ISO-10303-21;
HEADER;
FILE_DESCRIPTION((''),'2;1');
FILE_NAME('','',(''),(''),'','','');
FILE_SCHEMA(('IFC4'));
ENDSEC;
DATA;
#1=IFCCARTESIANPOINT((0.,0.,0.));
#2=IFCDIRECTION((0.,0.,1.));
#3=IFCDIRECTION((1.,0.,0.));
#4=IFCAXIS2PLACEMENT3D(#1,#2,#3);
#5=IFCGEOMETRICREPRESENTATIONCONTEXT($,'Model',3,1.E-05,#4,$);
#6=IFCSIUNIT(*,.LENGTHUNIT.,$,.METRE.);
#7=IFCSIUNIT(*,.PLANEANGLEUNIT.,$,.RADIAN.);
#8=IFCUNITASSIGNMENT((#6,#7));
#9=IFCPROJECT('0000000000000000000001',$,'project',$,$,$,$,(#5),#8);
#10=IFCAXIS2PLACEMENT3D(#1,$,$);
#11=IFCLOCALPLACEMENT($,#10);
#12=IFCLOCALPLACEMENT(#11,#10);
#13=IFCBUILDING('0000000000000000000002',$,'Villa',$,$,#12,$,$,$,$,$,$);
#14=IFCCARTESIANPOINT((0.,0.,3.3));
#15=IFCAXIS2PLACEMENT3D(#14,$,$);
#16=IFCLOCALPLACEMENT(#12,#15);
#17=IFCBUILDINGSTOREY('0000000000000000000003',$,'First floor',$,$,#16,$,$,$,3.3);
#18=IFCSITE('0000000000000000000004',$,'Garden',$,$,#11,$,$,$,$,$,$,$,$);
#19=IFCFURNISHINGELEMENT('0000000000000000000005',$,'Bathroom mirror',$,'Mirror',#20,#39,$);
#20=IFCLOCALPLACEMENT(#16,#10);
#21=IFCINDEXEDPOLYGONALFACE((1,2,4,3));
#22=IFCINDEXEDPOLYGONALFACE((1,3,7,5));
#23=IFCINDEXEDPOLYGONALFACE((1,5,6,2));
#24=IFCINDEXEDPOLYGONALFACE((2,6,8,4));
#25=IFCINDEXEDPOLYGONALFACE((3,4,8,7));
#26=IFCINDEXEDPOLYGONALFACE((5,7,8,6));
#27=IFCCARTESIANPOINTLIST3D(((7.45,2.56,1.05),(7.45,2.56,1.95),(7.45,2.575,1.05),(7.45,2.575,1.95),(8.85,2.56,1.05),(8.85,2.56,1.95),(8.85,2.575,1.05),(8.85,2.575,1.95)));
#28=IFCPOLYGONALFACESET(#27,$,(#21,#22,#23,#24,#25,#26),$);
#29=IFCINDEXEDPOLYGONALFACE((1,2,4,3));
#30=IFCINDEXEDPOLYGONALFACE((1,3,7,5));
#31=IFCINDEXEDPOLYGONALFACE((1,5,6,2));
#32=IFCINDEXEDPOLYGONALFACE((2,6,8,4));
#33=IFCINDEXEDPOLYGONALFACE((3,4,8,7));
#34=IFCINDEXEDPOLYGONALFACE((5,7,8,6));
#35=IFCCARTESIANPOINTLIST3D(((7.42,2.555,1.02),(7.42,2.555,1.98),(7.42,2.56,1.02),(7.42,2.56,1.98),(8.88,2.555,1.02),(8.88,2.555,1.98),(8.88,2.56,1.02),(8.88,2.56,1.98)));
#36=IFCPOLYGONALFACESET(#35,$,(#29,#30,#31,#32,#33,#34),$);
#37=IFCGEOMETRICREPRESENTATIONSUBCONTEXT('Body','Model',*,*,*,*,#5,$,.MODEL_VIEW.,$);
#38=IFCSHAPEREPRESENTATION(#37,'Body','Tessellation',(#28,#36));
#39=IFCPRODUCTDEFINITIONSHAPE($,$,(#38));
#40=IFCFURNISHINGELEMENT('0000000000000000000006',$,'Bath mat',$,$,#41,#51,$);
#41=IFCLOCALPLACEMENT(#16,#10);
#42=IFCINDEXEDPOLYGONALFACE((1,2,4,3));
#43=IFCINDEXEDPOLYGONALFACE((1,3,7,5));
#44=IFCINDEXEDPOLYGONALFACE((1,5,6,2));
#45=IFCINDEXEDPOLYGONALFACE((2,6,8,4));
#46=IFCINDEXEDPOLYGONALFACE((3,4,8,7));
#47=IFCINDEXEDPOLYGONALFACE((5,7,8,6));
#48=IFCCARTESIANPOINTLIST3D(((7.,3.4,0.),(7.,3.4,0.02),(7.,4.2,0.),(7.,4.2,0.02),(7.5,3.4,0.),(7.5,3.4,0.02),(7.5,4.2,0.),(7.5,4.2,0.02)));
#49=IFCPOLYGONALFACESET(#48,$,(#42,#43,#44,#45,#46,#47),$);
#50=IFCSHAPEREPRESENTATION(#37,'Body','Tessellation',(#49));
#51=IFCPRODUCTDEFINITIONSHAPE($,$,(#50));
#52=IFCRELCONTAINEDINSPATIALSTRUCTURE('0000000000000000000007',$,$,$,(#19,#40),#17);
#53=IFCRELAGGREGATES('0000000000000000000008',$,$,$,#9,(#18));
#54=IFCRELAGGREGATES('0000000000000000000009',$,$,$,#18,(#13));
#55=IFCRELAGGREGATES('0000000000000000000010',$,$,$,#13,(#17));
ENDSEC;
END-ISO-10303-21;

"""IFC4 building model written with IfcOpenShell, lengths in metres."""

from ifc_helpers import new_model, si_unit, frame, frame_2d, origin, origin_with_axes, place, context, subcontext, project, spatial, rectangle, extrude, element, save


model = new_model("IFC4")

# Units and contexts
model_context = context("Model", 3, precision=1e-05, world=origin_with_axes())
body_context = subcontext(model_context, "Body", "Model", "MODEL_VIEW")
ifc_project = project(units=[si_unit("LENGTHUNIT", "METRE"), si_unit("PLANEANGLEUNIT", "RADIAN")], contexts=[model_context])

# Site, building, storey
site_placement = place(None, origin())
site = spatial("IfcSite", under=ifc_project, at=site_placement, Name="Garden")
building_placement = place(site_placement, origin())
building = spatial("IfcBuilding", under=site, at=building_placement, Name="Villa")
storey_placement = place(building_placement, frame((0.0, 0.0, 3.3)))
storey = spatial("IfcBuildingStorey", under=building, at=storey_placement, Name="First floor", Elevation=3.3)

# Furnishing elements
furnishing_1_placement = place(storey_placement, origin())
element("IfcFurnishingElement", 1, at=furnishing_1_placement, inside=storey, Name="Bathroom mirror", ObjectType="Mirror", context=body_context, shape_type="SweptSolid", body=[
    extrude(rectangle(XDim=1.4, YDim=0.015, at=frame_2d((0.7, 0.0075))), frame((7.45, 2.56, 1.05)), (0.0, 0.0, 1.0), 0.9),
    extrude(rectangle(XDim=1.46, YDim=0.005, at=frame_2d((0.73, 0.0025))), frame((7.42, 2.555, 1.02)), (0.0, 0.0, 1.0), 0.96),
])
furnishing_2_placement = place(storey_placement, origin())
element("IfcFurnishingElement", 2, at=furnishing_2_placement, inside=storey, Name="Bath mat", context=body_context, shape_type="SweptSolid", body=[
    extrude(rectangle(XDim=0.5, YDim=0.8, at=frame_2d((0.25, 0.4))), frame((7.0, 3.4, 0.0)), (0.0, 0.0, 1.0), 0.02),
])

save(model, "model.ifc")
